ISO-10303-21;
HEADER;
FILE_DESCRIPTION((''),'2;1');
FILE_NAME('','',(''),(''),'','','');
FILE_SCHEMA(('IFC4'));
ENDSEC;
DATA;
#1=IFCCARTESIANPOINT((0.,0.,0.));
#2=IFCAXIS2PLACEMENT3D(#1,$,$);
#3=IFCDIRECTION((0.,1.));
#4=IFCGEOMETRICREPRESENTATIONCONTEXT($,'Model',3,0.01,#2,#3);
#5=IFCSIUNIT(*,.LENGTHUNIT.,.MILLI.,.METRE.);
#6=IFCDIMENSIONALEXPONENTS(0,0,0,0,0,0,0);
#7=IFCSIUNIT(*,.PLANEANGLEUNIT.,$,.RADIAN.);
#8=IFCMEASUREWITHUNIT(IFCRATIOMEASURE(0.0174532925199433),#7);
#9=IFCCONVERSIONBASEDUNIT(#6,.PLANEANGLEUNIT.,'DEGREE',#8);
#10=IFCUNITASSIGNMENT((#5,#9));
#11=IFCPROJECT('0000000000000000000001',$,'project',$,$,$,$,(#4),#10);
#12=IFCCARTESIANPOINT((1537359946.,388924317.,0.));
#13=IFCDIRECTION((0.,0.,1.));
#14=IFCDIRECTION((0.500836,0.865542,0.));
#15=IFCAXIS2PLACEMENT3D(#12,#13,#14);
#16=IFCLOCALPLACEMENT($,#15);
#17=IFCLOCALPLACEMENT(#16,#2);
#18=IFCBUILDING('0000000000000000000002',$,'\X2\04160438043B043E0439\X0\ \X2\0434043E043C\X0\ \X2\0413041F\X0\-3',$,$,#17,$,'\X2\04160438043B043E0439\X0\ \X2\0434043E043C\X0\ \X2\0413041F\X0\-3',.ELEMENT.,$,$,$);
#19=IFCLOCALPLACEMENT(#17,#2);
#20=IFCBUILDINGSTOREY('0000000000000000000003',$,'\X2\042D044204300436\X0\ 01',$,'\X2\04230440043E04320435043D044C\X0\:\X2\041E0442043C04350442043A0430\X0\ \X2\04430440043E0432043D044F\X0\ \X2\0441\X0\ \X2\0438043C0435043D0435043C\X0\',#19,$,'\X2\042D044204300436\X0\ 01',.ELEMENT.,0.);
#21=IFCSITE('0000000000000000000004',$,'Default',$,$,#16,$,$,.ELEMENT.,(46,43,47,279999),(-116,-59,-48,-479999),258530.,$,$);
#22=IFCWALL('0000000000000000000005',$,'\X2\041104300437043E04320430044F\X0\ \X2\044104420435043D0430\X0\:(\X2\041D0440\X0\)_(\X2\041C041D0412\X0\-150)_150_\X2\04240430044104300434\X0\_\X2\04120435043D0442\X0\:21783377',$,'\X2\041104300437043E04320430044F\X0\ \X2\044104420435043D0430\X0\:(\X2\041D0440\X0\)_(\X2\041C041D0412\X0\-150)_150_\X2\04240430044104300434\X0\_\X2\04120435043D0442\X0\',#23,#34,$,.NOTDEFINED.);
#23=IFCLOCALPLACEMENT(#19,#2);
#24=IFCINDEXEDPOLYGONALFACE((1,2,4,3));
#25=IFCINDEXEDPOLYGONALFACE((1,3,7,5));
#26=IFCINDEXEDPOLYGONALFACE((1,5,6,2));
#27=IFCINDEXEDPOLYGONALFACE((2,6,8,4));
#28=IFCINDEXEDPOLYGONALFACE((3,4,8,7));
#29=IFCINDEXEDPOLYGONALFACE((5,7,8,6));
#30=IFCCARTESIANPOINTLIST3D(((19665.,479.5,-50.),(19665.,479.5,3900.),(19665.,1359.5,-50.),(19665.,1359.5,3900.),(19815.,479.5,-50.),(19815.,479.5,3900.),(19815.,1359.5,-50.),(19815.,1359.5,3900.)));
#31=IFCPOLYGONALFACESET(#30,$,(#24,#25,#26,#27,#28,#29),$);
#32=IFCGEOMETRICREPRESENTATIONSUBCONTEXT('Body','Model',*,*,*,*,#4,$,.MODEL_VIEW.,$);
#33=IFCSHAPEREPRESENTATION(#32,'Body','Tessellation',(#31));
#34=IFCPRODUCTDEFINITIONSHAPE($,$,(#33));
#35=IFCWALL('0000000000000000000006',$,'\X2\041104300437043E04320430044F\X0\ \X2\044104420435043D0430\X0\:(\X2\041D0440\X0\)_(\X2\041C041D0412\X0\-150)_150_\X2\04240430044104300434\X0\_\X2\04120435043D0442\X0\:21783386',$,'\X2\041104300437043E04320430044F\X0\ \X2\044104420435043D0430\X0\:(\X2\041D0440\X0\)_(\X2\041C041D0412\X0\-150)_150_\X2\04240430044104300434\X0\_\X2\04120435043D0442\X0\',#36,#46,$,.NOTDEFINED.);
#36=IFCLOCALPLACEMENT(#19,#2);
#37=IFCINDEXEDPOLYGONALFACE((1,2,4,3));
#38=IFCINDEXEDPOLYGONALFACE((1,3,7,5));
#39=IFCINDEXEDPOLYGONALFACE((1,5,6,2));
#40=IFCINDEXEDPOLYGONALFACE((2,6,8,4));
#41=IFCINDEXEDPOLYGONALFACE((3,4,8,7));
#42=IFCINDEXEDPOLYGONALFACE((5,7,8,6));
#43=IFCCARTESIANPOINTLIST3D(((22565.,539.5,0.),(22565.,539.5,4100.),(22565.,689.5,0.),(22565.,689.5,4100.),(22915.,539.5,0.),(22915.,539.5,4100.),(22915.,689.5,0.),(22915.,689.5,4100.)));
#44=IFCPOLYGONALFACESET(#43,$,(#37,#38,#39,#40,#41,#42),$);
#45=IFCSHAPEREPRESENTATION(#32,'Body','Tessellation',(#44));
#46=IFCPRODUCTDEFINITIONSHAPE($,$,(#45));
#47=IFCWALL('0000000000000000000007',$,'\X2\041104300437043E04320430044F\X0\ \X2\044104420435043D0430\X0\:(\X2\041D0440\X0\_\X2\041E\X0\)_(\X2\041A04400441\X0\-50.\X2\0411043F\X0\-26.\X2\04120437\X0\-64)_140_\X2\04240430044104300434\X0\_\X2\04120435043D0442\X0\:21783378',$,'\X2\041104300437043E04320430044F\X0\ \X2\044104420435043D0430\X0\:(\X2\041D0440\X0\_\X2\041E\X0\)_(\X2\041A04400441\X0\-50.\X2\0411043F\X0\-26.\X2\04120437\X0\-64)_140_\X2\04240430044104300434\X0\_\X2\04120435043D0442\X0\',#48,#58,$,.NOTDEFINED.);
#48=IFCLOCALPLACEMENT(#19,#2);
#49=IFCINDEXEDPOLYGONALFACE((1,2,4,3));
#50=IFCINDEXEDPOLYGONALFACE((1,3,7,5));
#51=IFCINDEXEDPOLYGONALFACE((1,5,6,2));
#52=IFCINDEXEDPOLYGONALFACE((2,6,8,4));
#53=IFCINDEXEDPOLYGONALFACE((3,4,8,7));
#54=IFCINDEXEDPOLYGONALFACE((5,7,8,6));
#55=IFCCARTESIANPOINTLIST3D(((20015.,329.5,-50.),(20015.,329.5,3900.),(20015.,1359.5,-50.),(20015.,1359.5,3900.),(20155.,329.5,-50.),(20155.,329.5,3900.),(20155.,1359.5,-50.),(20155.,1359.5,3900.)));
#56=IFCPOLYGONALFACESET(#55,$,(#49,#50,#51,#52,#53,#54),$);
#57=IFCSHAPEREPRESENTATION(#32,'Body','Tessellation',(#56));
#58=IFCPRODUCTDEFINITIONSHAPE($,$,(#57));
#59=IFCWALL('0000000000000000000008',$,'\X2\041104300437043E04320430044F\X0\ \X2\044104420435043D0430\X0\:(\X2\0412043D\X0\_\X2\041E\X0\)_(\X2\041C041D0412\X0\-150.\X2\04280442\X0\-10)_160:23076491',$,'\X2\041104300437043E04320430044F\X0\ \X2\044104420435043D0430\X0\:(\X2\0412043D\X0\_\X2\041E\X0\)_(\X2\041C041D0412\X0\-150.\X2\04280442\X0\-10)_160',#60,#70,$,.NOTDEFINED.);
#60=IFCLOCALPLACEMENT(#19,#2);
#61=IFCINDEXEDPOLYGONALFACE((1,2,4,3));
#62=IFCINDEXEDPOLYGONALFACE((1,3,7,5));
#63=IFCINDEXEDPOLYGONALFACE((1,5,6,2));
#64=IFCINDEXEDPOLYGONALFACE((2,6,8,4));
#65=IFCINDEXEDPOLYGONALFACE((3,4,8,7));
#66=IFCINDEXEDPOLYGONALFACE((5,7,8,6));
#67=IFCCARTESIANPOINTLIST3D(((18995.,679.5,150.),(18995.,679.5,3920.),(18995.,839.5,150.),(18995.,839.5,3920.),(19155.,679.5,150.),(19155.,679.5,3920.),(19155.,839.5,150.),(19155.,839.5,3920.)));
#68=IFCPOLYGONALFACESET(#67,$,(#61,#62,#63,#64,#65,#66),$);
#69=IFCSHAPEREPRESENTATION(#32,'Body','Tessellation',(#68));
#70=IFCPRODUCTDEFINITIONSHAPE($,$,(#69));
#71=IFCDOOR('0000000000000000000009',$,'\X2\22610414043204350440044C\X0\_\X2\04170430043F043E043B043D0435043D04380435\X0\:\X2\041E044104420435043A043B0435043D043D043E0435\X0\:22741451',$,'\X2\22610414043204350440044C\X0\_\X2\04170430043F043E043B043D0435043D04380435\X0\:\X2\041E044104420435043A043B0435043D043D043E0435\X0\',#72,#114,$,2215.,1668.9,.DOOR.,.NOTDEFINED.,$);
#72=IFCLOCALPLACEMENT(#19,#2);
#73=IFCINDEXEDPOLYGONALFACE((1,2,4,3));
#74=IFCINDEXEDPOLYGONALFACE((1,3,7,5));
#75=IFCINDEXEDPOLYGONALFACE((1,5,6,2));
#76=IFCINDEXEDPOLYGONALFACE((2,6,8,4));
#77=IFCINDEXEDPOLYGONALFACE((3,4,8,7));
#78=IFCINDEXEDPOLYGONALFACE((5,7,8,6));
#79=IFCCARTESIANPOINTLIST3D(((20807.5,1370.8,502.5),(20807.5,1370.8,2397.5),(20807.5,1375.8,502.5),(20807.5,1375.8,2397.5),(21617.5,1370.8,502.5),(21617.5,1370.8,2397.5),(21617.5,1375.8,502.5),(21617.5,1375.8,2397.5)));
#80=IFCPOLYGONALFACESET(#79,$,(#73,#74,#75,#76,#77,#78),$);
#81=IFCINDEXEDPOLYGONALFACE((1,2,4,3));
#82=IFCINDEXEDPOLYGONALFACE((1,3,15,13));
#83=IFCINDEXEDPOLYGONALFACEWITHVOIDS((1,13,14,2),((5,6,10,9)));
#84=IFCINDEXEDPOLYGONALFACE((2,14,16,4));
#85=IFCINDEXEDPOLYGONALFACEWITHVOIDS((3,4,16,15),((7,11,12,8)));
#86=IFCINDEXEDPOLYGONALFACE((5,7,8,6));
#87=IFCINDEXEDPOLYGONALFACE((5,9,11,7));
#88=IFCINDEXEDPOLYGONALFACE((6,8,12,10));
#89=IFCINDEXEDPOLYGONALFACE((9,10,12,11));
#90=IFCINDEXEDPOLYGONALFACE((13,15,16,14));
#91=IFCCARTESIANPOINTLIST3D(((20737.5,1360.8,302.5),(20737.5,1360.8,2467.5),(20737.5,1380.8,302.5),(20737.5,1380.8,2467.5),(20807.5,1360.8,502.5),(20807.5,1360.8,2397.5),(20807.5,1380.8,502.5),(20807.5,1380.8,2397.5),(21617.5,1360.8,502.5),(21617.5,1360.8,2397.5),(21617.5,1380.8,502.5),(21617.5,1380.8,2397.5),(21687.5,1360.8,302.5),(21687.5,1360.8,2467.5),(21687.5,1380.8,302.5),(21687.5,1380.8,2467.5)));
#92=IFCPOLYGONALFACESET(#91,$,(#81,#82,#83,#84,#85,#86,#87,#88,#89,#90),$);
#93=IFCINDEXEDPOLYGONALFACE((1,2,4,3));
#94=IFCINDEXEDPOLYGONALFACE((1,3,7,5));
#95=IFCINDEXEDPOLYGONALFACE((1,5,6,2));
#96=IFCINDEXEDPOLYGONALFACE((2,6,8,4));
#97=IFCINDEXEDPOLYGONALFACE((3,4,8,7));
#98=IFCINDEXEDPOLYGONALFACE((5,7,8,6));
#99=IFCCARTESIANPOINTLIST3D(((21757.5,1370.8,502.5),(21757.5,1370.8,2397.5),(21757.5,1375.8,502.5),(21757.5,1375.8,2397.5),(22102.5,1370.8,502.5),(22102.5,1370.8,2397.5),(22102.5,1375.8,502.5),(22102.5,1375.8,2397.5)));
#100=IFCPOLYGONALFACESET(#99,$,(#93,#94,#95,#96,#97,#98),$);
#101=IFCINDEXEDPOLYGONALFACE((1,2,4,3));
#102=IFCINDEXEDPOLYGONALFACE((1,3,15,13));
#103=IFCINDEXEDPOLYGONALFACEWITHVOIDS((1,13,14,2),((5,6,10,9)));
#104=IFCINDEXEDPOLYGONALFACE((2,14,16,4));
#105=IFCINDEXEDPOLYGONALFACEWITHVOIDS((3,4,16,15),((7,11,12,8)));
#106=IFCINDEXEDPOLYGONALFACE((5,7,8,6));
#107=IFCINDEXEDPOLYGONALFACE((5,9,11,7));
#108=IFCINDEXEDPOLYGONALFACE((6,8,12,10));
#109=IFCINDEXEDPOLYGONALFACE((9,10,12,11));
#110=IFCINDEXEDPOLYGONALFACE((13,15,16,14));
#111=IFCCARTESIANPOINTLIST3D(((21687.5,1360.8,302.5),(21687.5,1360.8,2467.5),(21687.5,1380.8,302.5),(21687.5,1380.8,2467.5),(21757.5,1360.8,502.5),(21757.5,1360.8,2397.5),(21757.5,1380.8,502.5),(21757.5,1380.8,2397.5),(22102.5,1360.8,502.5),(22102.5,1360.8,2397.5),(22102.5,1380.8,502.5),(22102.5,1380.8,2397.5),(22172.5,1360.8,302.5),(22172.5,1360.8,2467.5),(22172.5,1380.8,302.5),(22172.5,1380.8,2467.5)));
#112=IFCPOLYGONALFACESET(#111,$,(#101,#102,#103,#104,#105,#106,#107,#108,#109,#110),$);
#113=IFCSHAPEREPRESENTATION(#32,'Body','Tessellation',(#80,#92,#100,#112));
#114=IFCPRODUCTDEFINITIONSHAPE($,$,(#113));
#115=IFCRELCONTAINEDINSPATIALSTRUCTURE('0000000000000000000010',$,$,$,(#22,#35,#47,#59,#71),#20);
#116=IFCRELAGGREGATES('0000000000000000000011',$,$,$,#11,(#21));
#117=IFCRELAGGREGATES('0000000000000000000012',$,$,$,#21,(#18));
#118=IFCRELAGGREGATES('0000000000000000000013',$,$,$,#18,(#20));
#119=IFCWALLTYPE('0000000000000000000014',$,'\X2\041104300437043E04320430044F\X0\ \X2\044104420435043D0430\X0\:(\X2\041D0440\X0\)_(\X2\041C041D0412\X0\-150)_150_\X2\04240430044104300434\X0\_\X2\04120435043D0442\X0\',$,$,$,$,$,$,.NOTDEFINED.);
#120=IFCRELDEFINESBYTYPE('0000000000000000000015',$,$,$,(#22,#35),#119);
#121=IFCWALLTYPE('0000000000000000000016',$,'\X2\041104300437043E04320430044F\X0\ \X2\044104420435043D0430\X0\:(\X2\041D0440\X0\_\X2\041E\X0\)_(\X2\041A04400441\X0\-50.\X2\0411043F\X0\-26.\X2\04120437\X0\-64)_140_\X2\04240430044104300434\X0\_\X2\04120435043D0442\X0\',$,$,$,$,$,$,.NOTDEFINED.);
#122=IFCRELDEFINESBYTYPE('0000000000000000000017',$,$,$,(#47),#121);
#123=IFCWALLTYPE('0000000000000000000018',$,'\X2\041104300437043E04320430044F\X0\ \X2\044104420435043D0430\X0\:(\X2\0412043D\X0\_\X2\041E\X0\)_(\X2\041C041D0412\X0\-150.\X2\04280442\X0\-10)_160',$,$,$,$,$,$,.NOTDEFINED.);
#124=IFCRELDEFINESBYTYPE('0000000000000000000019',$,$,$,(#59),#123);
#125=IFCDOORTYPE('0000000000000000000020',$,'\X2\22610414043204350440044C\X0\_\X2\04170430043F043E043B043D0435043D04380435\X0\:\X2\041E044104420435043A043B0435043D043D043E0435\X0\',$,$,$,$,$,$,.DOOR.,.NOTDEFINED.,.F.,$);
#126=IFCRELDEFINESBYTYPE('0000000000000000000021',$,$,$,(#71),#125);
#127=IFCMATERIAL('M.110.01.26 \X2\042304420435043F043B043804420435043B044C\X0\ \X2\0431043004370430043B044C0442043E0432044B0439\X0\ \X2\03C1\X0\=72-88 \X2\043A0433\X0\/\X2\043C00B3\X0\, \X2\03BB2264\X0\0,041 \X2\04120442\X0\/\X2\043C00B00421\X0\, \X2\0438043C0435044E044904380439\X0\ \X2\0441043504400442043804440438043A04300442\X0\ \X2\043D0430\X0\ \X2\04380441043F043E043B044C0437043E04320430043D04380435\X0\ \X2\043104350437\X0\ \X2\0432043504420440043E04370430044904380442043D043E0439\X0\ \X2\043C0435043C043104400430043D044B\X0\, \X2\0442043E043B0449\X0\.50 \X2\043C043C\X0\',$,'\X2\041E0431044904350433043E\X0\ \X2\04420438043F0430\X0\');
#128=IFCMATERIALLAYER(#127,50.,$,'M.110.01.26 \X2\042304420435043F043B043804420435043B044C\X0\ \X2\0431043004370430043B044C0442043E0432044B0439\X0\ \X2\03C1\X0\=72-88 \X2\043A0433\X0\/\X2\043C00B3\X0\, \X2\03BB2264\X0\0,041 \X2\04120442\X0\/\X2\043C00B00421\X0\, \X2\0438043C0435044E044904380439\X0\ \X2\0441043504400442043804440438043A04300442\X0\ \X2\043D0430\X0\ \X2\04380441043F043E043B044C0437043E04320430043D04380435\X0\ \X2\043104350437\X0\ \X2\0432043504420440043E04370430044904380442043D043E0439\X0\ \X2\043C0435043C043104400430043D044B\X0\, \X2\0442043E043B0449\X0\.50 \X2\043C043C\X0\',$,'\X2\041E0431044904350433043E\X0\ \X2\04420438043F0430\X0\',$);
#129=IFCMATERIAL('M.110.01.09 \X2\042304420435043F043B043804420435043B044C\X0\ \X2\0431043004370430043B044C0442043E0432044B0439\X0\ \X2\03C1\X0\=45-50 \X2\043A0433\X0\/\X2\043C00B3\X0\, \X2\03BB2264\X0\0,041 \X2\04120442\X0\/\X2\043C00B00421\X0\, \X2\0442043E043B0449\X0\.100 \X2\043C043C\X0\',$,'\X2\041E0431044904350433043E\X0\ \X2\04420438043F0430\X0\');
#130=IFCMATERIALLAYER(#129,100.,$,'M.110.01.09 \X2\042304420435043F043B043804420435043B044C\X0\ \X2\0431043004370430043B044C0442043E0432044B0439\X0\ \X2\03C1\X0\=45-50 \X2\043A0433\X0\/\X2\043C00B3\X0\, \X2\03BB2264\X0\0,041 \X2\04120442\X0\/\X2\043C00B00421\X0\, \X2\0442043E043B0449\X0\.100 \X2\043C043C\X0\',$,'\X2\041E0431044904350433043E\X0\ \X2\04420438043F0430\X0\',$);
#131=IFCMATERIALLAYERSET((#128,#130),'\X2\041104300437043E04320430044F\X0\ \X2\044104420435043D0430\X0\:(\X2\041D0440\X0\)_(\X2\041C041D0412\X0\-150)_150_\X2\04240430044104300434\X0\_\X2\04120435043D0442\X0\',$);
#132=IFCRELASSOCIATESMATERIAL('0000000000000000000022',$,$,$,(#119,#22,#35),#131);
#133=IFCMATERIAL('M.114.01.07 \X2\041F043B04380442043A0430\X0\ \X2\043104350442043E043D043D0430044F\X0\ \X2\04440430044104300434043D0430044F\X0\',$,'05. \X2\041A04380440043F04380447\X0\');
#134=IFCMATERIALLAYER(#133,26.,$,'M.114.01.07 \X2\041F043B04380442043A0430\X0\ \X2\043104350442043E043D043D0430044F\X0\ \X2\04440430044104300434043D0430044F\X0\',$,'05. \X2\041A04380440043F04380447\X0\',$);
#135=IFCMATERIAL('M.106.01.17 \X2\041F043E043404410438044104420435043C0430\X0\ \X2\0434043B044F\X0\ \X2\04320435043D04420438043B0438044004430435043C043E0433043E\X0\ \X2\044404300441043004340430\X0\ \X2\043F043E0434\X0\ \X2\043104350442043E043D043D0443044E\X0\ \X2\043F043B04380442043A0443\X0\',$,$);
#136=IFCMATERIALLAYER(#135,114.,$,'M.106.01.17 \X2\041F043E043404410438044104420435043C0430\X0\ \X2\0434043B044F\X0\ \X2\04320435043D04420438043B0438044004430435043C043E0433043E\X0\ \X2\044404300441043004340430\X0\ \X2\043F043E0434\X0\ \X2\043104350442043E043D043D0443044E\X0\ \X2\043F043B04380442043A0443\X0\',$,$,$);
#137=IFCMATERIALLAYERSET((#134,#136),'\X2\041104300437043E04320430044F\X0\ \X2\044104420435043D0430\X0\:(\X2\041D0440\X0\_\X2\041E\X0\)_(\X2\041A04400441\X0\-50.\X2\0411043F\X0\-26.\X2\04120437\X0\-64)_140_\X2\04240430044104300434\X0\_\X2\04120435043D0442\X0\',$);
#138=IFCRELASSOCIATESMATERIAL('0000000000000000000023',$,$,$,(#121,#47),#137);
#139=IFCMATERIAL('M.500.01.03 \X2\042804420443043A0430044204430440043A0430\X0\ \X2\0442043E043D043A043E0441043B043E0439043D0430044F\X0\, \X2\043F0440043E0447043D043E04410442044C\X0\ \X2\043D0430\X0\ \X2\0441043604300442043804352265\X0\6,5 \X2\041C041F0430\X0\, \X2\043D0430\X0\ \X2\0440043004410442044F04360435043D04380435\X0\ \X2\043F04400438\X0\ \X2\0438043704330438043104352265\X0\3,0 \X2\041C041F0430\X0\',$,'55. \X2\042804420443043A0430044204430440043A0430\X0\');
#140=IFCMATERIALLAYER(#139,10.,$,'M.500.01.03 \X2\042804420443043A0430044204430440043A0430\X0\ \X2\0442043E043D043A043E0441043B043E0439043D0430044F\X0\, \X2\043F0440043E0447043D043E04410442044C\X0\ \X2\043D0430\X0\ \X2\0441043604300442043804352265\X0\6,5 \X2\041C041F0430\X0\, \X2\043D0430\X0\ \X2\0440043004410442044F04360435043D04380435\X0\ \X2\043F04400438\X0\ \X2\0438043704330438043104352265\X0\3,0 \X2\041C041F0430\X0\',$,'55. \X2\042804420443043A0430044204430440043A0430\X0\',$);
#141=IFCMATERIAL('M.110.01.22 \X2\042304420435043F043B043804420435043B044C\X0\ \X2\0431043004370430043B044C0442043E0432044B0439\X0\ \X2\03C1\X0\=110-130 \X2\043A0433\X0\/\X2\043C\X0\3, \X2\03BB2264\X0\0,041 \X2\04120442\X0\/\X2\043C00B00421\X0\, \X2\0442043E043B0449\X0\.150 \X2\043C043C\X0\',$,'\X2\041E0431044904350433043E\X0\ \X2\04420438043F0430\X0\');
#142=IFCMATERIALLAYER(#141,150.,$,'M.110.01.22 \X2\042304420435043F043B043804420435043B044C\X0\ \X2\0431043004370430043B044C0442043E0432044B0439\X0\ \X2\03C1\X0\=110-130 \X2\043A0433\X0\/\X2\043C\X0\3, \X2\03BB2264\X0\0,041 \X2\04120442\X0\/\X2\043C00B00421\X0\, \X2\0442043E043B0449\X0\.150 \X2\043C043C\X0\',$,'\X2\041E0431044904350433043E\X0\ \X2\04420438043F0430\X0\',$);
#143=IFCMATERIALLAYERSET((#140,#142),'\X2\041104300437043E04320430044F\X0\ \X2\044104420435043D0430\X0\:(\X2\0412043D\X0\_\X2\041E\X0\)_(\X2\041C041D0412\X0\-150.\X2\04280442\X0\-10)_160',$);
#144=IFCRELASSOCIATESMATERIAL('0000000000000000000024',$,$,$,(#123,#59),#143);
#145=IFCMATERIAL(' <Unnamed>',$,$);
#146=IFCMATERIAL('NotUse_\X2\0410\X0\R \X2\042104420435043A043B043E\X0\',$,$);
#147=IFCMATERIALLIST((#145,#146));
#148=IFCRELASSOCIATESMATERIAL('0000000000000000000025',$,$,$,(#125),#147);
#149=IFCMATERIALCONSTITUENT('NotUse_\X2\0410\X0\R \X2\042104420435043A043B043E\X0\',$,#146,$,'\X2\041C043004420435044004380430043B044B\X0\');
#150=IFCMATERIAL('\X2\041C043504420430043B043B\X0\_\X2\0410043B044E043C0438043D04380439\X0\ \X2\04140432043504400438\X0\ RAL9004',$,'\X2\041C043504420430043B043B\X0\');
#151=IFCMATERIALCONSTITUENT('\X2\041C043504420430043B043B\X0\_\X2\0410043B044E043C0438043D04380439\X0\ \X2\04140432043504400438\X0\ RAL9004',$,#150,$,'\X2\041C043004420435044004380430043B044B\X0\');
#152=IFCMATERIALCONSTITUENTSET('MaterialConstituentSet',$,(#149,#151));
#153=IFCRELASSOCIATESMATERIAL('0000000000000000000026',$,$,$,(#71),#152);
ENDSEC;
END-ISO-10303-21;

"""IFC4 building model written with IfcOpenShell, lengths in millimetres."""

from ifc_helpers import new_model, entity, si_unit, converted_unit, direction, frame, frame_2d, origin, place, context, subcontext, project, spatial, polyline, rectangle, outline, extrude, source, transform, mapped, material, material_list, layer, layer_set, layer_usage, constituent, constituent_set, type_object, type_shapes, element, save


model = new_model("IFC4")

# Units and contexts
model_context = context("Model", 3, precision=0.01, world=origin(), true_north=direction((0.0, 1.0)))
body_context = subcontext(model_context, "Body", "Model", "MODEL_VIEW")
ifc_project = project(units=[si_unit("LENGTHUNIT", "METRE", prefix="MILLI"), converted_unit("PLANEANGLEUNIT", "DEGREE", entity("IfcRatioMeasure", 0.0174532925199433), si_unit("PLANEANGLEUNIT", "RADIAN"), dimensions=[0, 0, 0, 0, 0, 0, 0])], contexts=[model_context])

# Site, building, storey
site_placement = place(None, frame((1537359946.0, 388924317.0, 0.0), z_axis=(0.0, 0.0, 1.0), x_axis=(0.500836, 0.865542, 0.0)))
site = spatial("IfcSite", under=ifc_project, at=site_placement, Name="Default", CompositionType="ELEMENT", RefLatitude=(46, 43, 47, 279999), RefLongitude=(-116, -59, -48, -479999), RefElevation=258530.0)
building_placement = place(site_placement, origin())
building = spatial("IfcBuilding", under=site, at=building_placement, Name="Жилой дом ГП-3", LongName="Жилой дом ГП-3", CompositionType="ELEMENT")
storey_placement = place(building_placement, origin())
storey = spatial("IfcBuildingStorey", under=building, at=storey_placement, Name="Этаж 01", ObjectType="Уровень:Отметка уровня с именем", LongName="Этаж 01", CompositionType="ELEMENT", Elevation=0.0)

# Walls
ifc_material_1 = material(Name="M.110.01.26 Утеплитель базальтовый ρ=72-88 кг/м³, λ≤0,041 Вт/м°С, имеющий сертификат на использование без ветрозащитной мембраны, толщ.50 мм", Category="Общего типа")
ifc_layer_1 = layer(ifc_material_1, 50.0, Name="M.110.01.26 Утеплитель базальтовый ρ=72-88 кг/м³, λ≤0,041 Вт/м°С, имеющий сертификат на использование без ветрозащитной мембраны, толщ.50 мм", Category="Общего типа")
ifc_material_2 = material(Name="M.110.01.09 Утеплитель базальтовый ρ=45-50 кг/м³, λ≤0,041 Вт/м°С, толщ.100 мм", Category="Общего типа")
ifc_layer_2 = layer(ifc_material_2, 100.0, Name="M.110.01.09 Утеплитель базальтовый ρ=45-50 кг/м³, λ≤0,041 Вт/м°С, толщ.100 мм", Category="Общего типа")
ifc_layer_set_1 = layer_set([ifc_layer_1, ifc_layer_2], Name="Базовая стена:(Нр)_(МНВ-150)_150_Фасад_Вент")
ifc_layer_usage_1 = layer_usage(ifc_layer_set_1, "AXIS2", "NEGATIVE", 75.0)
wall_type_1 = type_object("IfcWallType", Name="Базовая стена:(Нр)_(МНВ-150)_150_Фасад_Вент", PredefinedType="NOTDEFINED", material=ifc_layer_set_1)
wall_1_placement = place(storey_placement, frame((19740.0, 1359.5, -50.0), z_axis=(0.0, 0.0, 1.0), x_axis=(0.0, -1.0, 0.0)))
element("IfcWall", 1, at=wall_1_placement, inside=storey, type_object=wall_type_1, material=ifc_layer_usage_1, Name="Базовая стена:(Нр)_(МНВ-150)_150_Фасад_Вент:21783377", ObjectType="Базовая стена:(Нр)_(МНВ-150)_150_Фасад_Вент", PredefinedType="NOTDEFINED", context=body_context, shape_type="SweptSolid", body=[
    extrude(rectangle(XDim=880.0, YDim=150.0, at=frame_2d((440.0, 0.0), x_axis=(-1.0, 0.0))), origin(), (0.0, 0.0, 1.0), 3950.0),
])
ifc_layer_usage_2 = layer_usage(ifc_layer_set_1, "AXIS2", "POSITIVE", -75.0)
wall_2_placement = place(storey_placement, frame((22565.0, 614.5, 0.0)))
element("IfcWall", 2, at=wall_2_placement, inside=storey, type_object=wall_type_1, material=ifc_layer_usage_2, Name="Базовая стена:(Нр)_(МНВ-150)_150_Фасад_Вент:21783386", ObjectType="Базовая стена:(Нр)_(МНВ-150)_150_Фасад_Вент", PredefinedType="NOTDEFINED", context=body_context, shape_type="SweptSolid", body=[
    extrude(rectangle(XDim=350.0, YDim=150.0, at=frame_2d((175.0, 0.0), x_axis=(-1.0, 0.0))), origin(), (0.0, 0.0, 1.0), 4100.0),
])
ifc_material_3 = material(Name="M.114.01.07 Плитка бетонная фасадная", Category="05. Кирпич")
ifc_layer_3 = layer(ifc_material_3, 26.0, Name="M.114.01.07 Плитка бетонная фасадная", Category="05. Кирпич")
ifc_material_4 = material(Name="M.106.01.17 Подсистема для вентилируемого фасада под бетонную плитку")
ifc_layer_4 = layer(ifc_material_4, 114.0, Name="M.106.01.17 Подсистема для вентилируемого фасада под бетонную плитку")
ifc_layer_set_2 = layer_set([ifc_layer_3, ifc_layer_4], Name="Базовая стена:(Нр_О)_(Крс-50.Бп-26.Вз-64)_140_Фасад_Вент")
ifc_layer_usage_3 = layer_usage(ifc_layer_set_2, "AXIS2", "POSITIVE", -70.0)
wall_type_2 = type_object("IfcWallType", Name="Базовая стена:(Нр_О)_(Крс-50.Бп-26.Вз-64)_140_Фасад_Вент", PredefinedType="NOTDEFINED", material=ifc_layer_set_2)
wall_3_placement = place(storey_placement, frame((20085.0, 329.5, -50.0), z_axis=(0.0, 0.0, 1.0), x_axis=(0.0, 1.0, 0.0)))
element("IfcWall", 3, at=wall_3_placement, inside=storey, type_object=wall_type_2, material=ifc_layer_usage_3, Name="Базовая стена:(Нр_О)_(Крс-50.Бп-26.Вз-64)_140_Фасад_Вент:21783378", ObjectType="Базовая стена:(Нр_О)_(Крс-50.Бп-26.Вз-64)_140_Фасад_Вент", PredefinedType="NOTDEFINED", context=body_context, shape_type="SweptSolid", body=[
    extrude(rectangle(XDim=1030.0, YDim=140.0, at=frame_2d((515.0, 0.0), x_axis=(-1.0, 0.0))), origin(), (0.0, 0.0, 1.0), 3950.0),
])

# Wall
ifc_material_5 = material(Name="M.500.01.03 Штукатурка тонкослойная, прочность на сжатие≥6,5 МПа, на растяжение при изгибе≥3,0 МПа", Category="55. Штукатурка")
ifc_layer_5 = layer(ifc_material_5, 10.0, Name="M.500.01.03 Штукатурка тонкослойная, прочность на сжатие≥6,5 МПа, на растяжение при изгибе≥3,0 МПа", Category="55. Штукатурка")
ifc_material_6 = material(Name="M.110.01.22 Утеплитель базальтовый ρ=110-130 кг/м3, λ≤0,041 Вт/м°С, толщ.150 мм", Category="Общего типа")
ifc_layer_6 = layer(ifc_material_6, 150.0, Name="M.110.01.22 Утеплитель базальтовый ρ=110-130 кг/м3, λ≤0,041 Вт/м°С, толщ.150 мм", Category="Общего типа")
ifc_layer_set_3 = layer_set([ifc_layer_5, ifc_layer_6], Name="Базовая стена:(Вн_О)_(МНВ-150.Шт-10)_160")
ifc_layer_usage_4 = layer_usage(ifc_layer_set_3, "AXIS2", "POSITIVE", -80.0)
wall_type_3 = type_object("IfcWallType", Name="Базовая стена:(Вн_О)_(МНВ-150.Шт-10)_160", PredefinedType="NOTDEFINED", material=ifc_layer_set_3)
wall_4_placement = place(storey_placement, frame((19155.0, 759.5, 150.0), z_axis=(0.0, 0.0, 1.0), x_axis=(-1.0, 0.0, 0.0)))
element("IfcWall", 4, at=wall_4_placement, inside=storey, type_object=wall_type_3, material=ifc_layer_usage_4, Name="Базовая стена:(Вн_О)_(МНВ-150.Шт-10)_160:23076491", ObjectType="Базовая стена:(Вн_О)_(МНВ-150.Шт-10)_160", PredefinedType="NOTDEFINED", context=body_context, shape_type="SweptSolid", body=[
    extrude(rectangle(XDim=160.0, YDim=160.0, at=frame_2d((80.0, 0.0), x_axis=(-1.0, 0.0))), origin(), (0.0, 0.0, 1.0), 3770.0),
])

# Door
ifc_material_7 = material(Name="NotUse_АR Стекло")
ifc_constituent_1 = constituent(ifc_material_7, Name="NotUse_АR Стекло", Category="Материалы")
ifc_material_8 = material(Name="Металл_Алюминий Двери RAL9004", Category="Металл")
ifc_constituent_2 = constituent(ifc_material_8, Name="Металл_Алюминий Двери RAL9004", Category="Материалы")
ifc_constituent_set = constituent_set(constituents=[ifc_constituent_1, ifc_constituent_2], Name="MaterialConstituentSet")
ifc_material_9 = material(Name=" <Unnamed>")
ifc_material_list = material_list([ifc_material_9, ifc_material_7])
door_type = type_object("IfcDoorType", Name="≡Дверь_Заполнение:Остекленное", OperationType="NOTDEFINED", ParameterTakesPrecedence=False, PredefinedType="DOOR", material=ifc_material_list)
shared_shape_1 = source(origin(), body_context, "Body", "SweptSolid", [
    extrude(rectangle(XDim=810.0, YDim=5.0, at=frame_2d((0.0, 0.0), x_axis=(1.0, 0.0))), frame((-242.5, 12.5, 200.0), z_axis=(0.0, 0.0, 1.0), x_axis=(-1.0, 0.0, 0.0)), (0.0, 0.0, 1.0), 1895.0),
    extrude(outline(polyline([(-1082.5, -475.0), (1082.5, -475.0), (1082.5, 475.0), (-1082.5, 475.0), (-1082.5, -475.0)]), holes=[polyline([(-1012.5, -405.0), (-1012.5, 405.0), (882.5, 405.0), (882.5, -405.0), (-1012.5, -405.0)])]), frame((-242.5, 0.0, 1082.5), z_axis=(0.0, 1.0, 0.0), x_axis=(0.0, 0.0, -1.0)), (0.0, 0.0, 1.0), 20.0),
    extrude(rectangle(XDim=345.0, YDim=5.0, at=frame_2d((0.0, 0.0), x_axis=(1.0, 0.0))), frame((475.0, 12.5, 200.0), z_axis=(0.0, 0.0, 1.0), x_axis=(-1.0, 0.0, 0.0)), (0.0, 0.0, 1.0), 1895.0),
    extrude(outline(polyline([(-1082.5, -242.5), (1082.5, -242.5), (1082.5, 242.5), (-1082.5, 242.5), (-1082.5, -242.5)]), holes=[polyline([(-1012.5, -172.5), (-1012.5, 172.5), (882.5, 172.5), (882.5, -172.5), (-1012.5, -172.5)])]), frame((475.0, 0.0, 1082.5), z_axis=(0.0, 1.0, 0.0), x_axis=(0.0, 0.0, -1.0)), (0.0, 0.0, 1.0), 20.0),
])
type_shapes(door_type, [shared_shape_1])
door_placement = place(storey_placement, frame((21455.0, 1360.8, 302.5)))
element("IfcDoor", 5, at=door_placement, inside=storey, type_object=door_type, material=ifc_constituent_set, Name="≡Дверь_Заполнение:Остекленное:22741451", ObjectType="≡Дверь_Заполнение:Остекленное", OperationType="NOTDEFINED", OverallHeight=2215.0, OverallWidth=1668.9, PredefinedType="DOOR", context=body_context, shape_type="MappedRepresentation", body=[
    mapped(shared_shape_1, transform((0.0, 0.0, 0.0), scale=1.0)),
])

save(model, "model.ifc")
